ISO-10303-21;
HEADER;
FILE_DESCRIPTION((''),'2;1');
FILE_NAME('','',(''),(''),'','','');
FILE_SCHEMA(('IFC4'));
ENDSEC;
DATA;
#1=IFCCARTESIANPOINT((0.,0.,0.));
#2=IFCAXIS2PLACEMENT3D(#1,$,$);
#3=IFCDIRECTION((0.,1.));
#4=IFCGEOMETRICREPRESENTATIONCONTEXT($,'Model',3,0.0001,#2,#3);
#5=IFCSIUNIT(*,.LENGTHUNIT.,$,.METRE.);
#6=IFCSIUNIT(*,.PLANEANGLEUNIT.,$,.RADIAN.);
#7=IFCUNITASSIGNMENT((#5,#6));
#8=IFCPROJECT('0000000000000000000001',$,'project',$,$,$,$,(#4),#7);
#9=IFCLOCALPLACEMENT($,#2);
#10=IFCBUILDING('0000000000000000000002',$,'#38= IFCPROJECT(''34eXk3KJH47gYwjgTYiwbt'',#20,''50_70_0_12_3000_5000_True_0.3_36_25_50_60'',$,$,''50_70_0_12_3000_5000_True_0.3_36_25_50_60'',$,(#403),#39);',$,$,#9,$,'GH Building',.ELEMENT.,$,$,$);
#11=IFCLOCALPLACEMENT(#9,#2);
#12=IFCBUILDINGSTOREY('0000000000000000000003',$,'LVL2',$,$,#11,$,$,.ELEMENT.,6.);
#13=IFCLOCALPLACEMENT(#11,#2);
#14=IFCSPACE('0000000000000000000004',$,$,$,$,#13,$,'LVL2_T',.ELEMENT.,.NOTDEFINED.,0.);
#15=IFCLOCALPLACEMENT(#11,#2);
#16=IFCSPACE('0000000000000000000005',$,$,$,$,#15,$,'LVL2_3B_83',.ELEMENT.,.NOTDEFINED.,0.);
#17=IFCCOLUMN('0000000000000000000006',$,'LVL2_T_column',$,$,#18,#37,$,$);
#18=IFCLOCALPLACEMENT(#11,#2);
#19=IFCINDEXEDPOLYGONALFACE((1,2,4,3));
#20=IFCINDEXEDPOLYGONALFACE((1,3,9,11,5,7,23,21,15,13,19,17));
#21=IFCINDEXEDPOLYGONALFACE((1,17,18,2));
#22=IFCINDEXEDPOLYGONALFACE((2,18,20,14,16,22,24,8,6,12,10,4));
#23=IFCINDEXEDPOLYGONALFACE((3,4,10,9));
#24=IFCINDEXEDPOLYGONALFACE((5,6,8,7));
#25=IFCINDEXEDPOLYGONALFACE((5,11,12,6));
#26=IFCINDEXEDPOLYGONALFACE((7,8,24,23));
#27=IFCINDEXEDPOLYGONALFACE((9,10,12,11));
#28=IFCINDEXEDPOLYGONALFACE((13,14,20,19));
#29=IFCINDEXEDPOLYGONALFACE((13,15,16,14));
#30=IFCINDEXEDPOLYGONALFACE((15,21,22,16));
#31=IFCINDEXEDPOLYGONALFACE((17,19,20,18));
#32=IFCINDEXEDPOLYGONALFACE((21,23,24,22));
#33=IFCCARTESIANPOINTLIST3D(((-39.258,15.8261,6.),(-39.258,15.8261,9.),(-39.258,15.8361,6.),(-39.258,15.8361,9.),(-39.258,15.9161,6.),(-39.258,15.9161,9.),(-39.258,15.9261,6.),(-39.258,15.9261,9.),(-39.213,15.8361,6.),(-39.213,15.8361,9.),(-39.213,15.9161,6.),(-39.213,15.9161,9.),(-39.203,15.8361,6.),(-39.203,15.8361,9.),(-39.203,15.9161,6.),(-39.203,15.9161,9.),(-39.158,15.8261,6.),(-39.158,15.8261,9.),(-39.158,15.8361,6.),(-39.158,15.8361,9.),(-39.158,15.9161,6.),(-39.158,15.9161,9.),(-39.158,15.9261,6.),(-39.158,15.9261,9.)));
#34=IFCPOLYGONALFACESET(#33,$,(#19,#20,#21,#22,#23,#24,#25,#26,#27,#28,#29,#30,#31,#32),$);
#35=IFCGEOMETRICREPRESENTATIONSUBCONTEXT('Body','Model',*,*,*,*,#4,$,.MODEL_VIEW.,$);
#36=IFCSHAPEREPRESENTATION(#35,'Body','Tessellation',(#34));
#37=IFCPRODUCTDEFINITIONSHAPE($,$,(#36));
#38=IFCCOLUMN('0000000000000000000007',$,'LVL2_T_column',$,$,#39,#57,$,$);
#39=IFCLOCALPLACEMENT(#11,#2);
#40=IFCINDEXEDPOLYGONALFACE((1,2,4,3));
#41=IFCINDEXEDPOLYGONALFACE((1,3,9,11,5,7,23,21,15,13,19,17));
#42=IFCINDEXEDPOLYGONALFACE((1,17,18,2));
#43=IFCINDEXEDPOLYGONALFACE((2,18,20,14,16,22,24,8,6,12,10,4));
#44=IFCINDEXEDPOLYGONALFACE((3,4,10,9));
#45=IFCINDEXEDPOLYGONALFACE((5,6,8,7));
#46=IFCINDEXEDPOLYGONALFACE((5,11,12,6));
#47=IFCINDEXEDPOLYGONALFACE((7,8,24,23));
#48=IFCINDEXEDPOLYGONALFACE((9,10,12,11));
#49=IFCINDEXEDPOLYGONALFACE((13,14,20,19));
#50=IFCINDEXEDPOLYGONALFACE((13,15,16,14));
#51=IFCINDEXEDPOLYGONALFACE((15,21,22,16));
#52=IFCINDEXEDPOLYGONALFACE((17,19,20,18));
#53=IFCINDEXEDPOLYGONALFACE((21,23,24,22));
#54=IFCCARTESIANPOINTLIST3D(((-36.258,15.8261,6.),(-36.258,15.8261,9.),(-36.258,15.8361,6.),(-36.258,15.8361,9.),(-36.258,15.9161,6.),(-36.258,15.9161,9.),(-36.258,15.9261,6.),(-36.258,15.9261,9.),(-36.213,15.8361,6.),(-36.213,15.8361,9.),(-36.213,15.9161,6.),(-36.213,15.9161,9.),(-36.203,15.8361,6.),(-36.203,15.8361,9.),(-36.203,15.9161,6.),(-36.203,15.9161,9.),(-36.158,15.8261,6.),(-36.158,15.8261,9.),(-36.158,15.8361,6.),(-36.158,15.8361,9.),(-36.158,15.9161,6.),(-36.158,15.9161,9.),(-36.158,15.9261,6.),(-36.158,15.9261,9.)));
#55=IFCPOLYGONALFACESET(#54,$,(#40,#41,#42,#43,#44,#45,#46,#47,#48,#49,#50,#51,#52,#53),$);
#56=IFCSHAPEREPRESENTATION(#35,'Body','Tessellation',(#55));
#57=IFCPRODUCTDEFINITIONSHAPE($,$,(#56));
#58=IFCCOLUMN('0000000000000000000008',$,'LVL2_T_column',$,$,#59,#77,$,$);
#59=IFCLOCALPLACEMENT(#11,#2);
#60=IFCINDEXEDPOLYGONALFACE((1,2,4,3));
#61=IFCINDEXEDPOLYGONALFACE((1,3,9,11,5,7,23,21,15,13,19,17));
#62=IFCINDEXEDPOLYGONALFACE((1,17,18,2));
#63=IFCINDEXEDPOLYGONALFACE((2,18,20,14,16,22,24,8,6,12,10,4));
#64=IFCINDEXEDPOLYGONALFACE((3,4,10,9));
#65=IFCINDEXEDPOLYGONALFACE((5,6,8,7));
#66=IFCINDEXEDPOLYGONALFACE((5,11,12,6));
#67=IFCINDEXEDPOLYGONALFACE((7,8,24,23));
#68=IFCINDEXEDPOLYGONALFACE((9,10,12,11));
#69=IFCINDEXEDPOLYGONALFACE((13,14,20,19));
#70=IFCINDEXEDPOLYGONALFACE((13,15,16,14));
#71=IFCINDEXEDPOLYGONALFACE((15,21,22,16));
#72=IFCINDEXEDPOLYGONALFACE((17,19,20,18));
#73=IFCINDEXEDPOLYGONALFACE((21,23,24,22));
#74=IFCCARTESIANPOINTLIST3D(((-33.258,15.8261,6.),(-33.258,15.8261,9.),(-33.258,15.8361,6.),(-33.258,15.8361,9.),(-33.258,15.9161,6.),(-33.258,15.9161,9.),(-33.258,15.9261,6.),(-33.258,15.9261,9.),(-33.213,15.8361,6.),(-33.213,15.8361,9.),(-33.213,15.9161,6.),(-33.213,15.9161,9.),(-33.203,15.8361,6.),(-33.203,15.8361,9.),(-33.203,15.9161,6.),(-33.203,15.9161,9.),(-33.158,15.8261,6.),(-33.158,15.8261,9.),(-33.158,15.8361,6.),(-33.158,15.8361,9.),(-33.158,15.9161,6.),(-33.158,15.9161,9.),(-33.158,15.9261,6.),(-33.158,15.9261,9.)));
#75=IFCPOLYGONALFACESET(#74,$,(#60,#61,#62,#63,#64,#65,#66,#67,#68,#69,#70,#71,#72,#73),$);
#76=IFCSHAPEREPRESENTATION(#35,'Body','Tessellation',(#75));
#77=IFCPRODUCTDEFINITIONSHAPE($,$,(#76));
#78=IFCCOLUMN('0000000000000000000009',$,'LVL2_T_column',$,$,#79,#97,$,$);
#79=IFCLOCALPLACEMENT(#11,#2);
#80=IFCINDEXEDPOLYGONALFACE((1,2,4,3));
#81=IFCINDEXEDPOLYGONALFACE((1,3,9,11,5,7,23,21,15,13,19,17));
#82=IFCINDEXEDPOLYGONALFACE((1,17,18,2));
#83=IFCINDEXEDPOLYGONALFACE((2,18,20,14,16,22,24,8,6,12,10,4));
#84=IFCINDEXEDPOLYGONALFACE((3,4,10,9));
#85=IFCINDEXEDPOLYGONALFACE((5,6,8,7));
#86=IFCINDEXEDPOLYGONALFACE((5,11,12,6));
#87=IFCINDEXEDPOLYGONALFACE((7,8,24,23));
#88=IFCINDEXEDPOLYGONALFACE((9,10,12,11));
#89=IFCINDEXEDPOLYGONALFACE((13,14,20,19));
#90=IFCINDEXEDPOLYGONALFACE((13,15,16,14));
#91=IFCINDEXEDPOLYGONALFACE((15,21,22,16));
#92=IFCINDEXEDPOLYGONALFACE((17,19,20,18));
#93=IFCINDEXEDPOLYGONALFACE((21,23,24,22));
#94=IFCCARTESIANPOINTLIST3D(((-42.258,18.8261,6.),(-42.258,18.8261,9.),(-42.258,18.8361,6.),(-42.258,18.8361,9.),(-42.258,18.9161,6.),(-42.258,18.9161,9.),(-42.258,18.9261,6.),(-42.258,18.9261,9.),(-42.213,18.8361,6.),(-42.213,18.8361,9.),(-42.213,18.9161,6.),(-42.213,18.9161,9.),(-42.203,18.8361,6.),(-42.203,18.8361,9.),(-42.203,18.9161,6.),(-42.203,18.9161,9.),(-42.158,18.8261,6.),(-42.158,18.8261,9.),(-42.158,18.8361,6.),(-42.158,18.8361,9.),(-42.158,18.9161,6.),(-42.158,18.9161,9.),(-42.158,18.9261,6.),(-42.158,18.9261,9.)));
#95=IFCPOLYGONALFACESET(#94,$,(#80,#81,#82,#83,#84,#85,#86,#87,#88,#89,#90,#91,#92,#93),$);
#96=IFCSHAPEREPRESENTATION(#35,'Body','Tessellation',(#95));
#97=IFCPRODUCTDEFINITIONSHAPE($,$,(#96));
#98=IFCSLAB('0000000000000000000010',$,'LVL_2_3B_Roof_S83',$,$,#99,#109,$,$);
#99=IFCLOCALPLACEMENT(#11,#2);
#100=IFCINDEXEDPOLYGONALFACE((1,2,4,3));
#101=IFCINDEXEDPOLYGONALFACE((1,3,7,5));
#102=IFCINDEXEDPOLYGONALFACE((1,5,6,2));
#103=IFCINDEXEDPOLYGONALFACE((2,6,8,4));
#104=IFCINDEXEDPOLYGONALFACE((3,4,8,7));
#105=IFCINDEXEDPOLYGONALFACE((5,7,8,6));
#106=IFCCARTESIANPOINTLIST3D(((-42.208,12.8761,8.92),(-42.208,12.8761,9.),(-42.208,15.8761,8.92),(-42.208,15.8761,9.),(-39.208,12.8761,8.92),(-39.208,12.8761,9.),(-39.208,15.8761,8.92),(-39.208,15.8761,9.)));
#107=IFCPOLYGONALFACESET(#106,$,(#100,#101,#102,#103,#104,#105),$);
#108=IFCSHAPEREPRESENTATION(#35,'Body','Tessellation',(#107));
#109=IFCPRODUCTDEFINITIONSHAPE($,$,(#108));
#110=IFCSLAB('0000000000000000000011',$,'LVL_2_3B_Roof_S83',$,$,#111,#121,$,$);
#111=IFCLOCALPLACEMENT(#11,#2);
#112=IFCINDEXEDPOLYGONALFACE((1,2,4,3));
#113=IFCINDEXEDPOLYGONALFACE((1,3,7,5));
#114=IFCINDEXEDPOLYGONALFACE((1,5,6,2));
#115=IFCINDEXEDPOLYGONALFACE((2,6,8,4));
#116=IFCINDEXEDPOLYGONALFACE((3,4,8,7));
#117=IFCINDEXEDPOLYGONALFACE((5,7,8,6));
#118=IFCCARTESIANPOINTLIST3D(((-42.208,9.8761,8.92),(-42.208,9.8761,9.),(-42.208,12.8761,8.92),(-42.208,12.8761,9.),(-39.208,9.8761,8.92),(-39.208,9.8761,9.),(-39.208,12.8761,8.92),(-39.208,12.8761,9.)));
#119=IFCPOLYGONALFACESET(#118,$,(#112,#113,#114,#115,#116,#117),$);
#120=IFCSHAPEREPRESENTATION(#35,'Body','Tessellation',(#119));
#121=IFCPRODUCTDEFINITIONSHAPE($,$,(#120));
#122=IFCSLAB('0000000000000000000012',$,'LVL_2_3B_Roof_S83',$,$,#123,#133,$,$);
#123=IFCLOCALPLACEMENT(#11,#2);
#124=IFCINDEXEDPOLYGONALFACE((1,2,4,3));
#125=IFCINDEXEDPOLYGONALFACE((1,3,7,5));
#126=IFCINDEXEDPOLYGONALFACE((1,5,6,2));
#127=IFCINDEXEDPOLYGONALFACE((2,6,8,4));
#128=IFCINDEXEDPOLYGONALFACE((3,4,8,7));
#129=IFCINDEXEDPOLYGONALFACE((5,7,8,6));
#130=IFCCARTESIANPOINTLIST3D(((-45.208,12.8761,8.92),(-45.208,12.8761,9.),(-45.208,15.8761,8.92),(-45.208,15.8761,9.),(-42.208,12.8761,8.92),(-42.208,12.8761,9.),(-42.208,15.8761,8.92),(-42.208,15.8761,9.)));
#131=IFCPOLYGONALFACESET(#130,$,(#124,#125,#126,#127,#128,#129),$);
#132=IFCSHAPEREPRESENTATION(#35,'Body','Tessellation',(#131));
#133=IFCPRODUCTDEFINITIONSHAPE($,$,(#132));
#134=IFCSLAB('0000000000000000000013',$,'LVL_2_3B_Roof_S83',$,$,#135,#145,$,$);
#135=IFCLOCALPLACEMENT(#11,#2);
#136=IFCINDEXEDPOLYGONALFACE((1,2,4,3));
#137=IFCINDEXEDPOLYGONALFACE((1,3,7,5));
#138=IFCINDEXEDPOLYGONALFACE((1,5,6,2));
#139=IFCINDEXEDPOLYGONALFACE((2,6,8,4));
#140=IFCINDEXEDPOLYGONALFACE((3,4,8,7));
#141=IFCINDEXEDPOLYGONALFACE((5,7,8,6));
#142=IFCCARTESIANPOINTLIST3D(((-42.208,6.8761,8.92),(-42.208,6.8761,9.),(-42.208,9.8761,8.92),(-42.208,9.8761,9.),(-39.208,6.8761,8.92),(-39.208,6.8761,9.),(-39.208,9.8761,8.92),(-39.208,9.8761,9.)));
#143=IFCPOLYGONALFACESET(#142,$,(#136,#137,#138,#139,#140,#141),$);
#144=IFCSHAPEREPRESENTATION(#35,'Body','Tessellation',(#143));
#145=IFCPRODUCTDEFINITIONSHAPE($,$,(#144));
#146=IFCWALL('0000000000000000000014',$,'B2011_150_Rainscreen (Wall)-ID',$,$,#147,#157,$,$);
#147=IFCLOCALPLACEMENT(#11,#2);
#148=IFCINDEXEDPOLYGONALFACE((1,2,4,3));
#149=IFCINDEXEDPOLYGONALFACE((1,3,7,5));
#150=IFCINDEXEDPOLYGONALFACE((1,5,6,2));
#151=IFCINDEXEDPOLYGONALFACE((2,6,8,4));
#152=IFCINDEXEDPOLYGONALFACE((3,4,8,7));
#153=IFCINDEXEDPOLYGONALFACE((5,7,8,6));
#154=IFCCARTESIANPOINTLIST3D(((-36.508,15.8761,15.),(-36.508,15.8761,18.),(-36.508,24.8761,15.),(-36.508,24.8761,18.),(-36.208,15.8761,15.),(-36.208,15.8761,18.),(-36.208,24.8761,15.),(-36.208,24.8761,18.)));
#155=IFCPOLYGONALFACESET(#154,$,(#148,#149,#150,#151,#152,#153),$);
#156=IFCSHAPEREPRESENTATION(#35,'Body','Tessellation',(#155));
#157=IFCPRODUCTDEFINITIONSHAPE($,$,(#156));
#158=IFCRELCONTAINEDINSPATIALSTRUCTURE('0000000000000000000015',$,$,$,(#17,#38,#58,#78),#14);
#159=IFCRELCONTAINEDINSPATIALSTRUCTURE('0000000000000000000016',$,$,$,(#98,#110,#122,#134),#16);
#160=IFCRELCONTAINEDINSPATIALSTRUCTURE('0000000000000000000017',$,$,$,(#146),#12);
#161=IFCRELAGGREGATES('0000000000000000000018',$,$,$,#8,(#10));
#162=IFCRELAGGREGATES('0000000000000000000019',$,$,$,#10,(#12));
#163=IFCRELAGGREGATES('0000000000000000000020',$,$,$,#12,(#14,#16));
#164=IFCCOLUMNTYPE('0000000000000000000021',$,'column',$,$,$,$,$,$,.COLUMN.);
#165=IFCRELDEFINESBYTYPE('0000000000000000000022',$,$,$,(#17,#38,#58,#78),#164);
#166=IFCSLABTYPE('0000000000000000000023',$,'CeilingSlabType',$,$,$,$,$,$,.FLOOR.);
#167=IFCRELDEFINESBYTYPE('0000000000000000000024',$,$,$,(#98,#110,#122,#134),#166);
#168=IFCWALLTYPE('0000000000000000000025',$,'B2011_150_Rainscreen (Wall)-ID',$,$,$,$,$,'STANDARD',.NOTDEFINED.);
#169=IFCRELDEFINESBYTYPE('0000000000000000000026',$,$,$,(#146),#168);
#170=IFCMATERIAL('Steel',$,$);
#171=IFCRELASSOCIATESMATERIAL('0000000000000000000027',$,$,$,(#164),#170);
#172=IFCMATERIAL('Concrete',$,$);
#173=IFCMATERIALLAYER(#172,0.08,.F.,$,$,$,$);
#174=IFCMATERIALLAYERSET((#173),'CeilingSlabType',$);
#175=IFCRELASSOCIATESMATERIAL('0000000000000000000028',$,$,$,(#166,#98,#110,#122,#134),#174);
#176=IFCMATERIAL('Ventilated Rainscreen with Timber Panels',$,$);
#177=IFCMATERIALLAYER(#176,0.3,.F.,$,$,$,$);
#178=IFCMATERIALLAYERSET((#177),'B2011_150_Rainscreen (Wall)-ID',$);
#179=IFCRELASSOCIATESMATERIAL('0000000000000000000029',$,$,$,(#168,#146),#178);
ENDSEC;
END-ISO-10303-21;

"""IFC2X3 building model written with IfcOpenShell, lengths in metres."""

from ifc_helpers import new_model, si_unit, direction, frame, frame_2d, origin, origin_2d, place, context, subcontext, project, spatial, rectangle, i_section, extrude, material, layer, layer_set, layer_usage, type_object, element, save


model = new_model("IFC2X3")

# Units and contexts
model_context = context("Model", 3, precision=0.0001, world=origin(), true_north=direction((0.0, 1.0)))
body_context = subcontext(model_context, "Body", "Model", "MODEL_VIEW")
ifc_project = project(units=[si_unit("LENGTHUNIT", "METRE"), si_unit("PLANEANGLEUNIT", "RADIAN")], contexts=[model_context])

# Building, storey, space
building_placement = place(None, origin())
building = spatial("IfcBuilding", under=ifc_project, at=building_placement, Name="#38= IFCPROJECT('34eXk3KJH47gYwjgTYiwbt',#20,'50_70_0_12_3000_5000_True_0.3_36_25_50_60',$,$,'50_70_0_12_3000_5000_True_0.3_36_25_50_60',$,(#403),#39);", LongName="GH Building", CompositionType="ELEMENT")
storey_placement = place(building_placement, origin())
storey = spatial("IfcBuildingStorey", under=building, at=storey_placement, Name="LVL2", CompositionType="ELEMENT", Elevation=6.0)
space_1_placement = place(storey_placement, origin())
space_1 = spatial("IfcSpace", under=storey, at=space_1_placement, LongName="LVL2_T", CompositionType="ELEMENT", InteriorOrExteriorSpace="NOTDEFINED", ElevationWithFlooring=0.0)

# Columns
ifc_material_1 = material(Name="Steel")
column_type = type_object("IfcColumnType", Name="column", PredefinedType="COLUMN", material=ifc_material_1)
for number, where, name in (
    (1, (-39.208, 15.8761, 6.0), "LVL2_T_column"),
    (2, (-36.208, 15.8761, 6.0), "LVL2_T_column"),
    (3, (-33.208, 15.8761, 6.0), "LVL2_T_column"),
    (4, (-42.208, 18.8761, 6.0), "LVL2_T_column"),
):
    element("IfcColumn", number, at=place(space_1_placement, frame(where)), inside=space_1, type_object=column_type, Name=name, context=body_context, shape_type="SweptSolid", body=[
        extrude(i_section(OverallWidth=0.1, OverallDepth=0.1, WebThickness=0.01, FlangeThickness=0.01, at=origin_2d()), origin(), (0.0, 0.0, 1.0), 3.0),
    ])

# Shared definitions
space_2_placement = place(storey_placement, origin())
space_2 = spatial("IfcSpace", under=storey, at=space_2_placement, LongName="LVL2_3B_83", CompositionType="ELEMENT", InteriorOrExteriorSpace="NOTDEFINED", ElevationWithFlooring=0.0)

# Slabs
ifc_material_2 = material(Name="Concrete")
ifc_layer_1 = layer(ifc_material_2, 0.08, ventilated=False)
ifc_layer_set_1 = layer_set([ifc_layer_1], Name="CeilingSlabType")
ifc_layer_usage_1 = layer_usage(ifc_layer_set_1, "AXIS3", "NEGATIVE", -0.08)
slab_type = type_object("IfcSlabType", Name="CeilingSlabType", PredefinedType="FLOOR", material=ifc_layer_set_1)
slab_1_placement = place(space_2_placement, frame((-42.208, 15.8761, 8.92), z_axis=(0.0, 0.0, 1.0), x_axis=(0.0, -1.0, 0.0)))
element("IfcSlab", 5, at=slab_1_placement, inside=space_2, type_object=slab_type, material=ifc_layer_usage_1, Name="LVL_2_3B_Roof_S83", context=body_context, shape_type="SweptSolid", body=[
    extrude(rectangle(XDim=3.0, YDim=3.0, at=frame_2d((1.5, 1.5))), origin(), (0.0, 0.0, 1.0), 0.08),
])
ifc_layer_usage_2 = layer_usage(ifc_layer_set_1, "AXIS3", "NEGATIVE", -0.08)
slab_2_placement = place(space_2_placement, frame((-42.208, 12.8761, 8.92), z_axis=(0.0, 0.0, 1.0), x_axis=(0.0, -1.0, 0.0)))
element("IfcSlab", 6, at=slab_2_placement, inside=space_2, type_object=slab_type, material=ifc_layer_usage_2, Name="LVL_2_3B_Roof_S83", context=body_context, shape_type="SweptSolid", body=[
    extrude(rectangle(XDim=3.0, YDim=3.0, at=frame_2d((1.5, 1.5))), origin(), (0.0, 0.0, 1.0), 0.08),
])
ifc_layer_usage_3 = layer_usage(ifc_layer_set_1, "AXIS3", "NEGATIVE", -0.08)
slab_3_placement = place(space_2_placement, frame((-45.208, 15.8761, 8.92), z_axis=(0.0, 0.0, 1.0), x_axis=(0.0, -1.0, 0.0)))
element("IfcSlab", 7, at=slab_3_placement, inside=space_2, type_object=slab_type, material=ifc_layer_usage_3, Name="LVL_2_3B_Roof_S83", context=body_context, shape_type="SweptSolid", body=[
    extrude(rectangle(XDim=3.0, YDim=3.0, at=frame_2d((1.5, 1.5))), origin(), (0.0, 0.0, 1.0), 0.08),
])
ifc_layer_usage_4 = layer_usage(ifc_layer_set_1, "AXIS3", "NEGATIVE", -0.08)
slab_4_placement = place(space_2_placement, frame((-42.208, 6.8761, 8.92), z_axis=(0.0, 0.0, 1.0), x_axis=(0.0, 1.0, 0.0)))
element("IfcSlab", 8, at=slab_4_placement, inside=space_2, type_object=slab_type, material=ifc_layer_usage_4, Name="LVL_2_3B_Roof_S83", context=body_context, shape_type="SweptSolid", body=[
    extrude(rectangle(XDim=3.0, YDim=3.0, at=frame_2d((1.5, -1.5))), origin(), (0.0, 0.0, 1.0), 0.08),
])

# Wall
ifc_material_3 = material(Name="Ventilated Rainscreen with Timber Panels")
ifc_layer_2 = layer(ifc_material_3, 0.3, ventilated=False)
ifc_layer_set_2 = layer_set([ifc_layer_2], Name="B2011_150_Rainscreen (Wall)-ID")
ifc_layer_usage_5 = layer_usage(ifc_layer_set_2, "AXIS2", "POSITIVE", 0.0)
wall_type_1 = type_object("IfcWallType", Name="B2011_150_Rainscreen (Wall)-ID", ElementType="STANDARD", PredefinedType="NOTDEFINED", material=ifc_layer_set_2)
wall_1_placement = place(storey_placement, frame((-36.208, 15.8761, 15.0), z_axis=(0.0, 0.0, 1.0), x_axis=(0.0, 1.0, 0.0)))
element("IfcWall", 9, at=wall_1_placement, inside=storey, type_object=wall_type_1, material=ifc_layer_usage_5, Name="B2011_150_Rainscreen (Wall)-ID", context=body_context, shape_type="SweptSolid", body=[
    extrude(rectangle(XDim=9.0, YDim=0.3, at=frame_2d((4.5, 0.15))), origin(), (0.0, 0.0, 1.0), 3.0),
])

save(model, "model.ifc")
